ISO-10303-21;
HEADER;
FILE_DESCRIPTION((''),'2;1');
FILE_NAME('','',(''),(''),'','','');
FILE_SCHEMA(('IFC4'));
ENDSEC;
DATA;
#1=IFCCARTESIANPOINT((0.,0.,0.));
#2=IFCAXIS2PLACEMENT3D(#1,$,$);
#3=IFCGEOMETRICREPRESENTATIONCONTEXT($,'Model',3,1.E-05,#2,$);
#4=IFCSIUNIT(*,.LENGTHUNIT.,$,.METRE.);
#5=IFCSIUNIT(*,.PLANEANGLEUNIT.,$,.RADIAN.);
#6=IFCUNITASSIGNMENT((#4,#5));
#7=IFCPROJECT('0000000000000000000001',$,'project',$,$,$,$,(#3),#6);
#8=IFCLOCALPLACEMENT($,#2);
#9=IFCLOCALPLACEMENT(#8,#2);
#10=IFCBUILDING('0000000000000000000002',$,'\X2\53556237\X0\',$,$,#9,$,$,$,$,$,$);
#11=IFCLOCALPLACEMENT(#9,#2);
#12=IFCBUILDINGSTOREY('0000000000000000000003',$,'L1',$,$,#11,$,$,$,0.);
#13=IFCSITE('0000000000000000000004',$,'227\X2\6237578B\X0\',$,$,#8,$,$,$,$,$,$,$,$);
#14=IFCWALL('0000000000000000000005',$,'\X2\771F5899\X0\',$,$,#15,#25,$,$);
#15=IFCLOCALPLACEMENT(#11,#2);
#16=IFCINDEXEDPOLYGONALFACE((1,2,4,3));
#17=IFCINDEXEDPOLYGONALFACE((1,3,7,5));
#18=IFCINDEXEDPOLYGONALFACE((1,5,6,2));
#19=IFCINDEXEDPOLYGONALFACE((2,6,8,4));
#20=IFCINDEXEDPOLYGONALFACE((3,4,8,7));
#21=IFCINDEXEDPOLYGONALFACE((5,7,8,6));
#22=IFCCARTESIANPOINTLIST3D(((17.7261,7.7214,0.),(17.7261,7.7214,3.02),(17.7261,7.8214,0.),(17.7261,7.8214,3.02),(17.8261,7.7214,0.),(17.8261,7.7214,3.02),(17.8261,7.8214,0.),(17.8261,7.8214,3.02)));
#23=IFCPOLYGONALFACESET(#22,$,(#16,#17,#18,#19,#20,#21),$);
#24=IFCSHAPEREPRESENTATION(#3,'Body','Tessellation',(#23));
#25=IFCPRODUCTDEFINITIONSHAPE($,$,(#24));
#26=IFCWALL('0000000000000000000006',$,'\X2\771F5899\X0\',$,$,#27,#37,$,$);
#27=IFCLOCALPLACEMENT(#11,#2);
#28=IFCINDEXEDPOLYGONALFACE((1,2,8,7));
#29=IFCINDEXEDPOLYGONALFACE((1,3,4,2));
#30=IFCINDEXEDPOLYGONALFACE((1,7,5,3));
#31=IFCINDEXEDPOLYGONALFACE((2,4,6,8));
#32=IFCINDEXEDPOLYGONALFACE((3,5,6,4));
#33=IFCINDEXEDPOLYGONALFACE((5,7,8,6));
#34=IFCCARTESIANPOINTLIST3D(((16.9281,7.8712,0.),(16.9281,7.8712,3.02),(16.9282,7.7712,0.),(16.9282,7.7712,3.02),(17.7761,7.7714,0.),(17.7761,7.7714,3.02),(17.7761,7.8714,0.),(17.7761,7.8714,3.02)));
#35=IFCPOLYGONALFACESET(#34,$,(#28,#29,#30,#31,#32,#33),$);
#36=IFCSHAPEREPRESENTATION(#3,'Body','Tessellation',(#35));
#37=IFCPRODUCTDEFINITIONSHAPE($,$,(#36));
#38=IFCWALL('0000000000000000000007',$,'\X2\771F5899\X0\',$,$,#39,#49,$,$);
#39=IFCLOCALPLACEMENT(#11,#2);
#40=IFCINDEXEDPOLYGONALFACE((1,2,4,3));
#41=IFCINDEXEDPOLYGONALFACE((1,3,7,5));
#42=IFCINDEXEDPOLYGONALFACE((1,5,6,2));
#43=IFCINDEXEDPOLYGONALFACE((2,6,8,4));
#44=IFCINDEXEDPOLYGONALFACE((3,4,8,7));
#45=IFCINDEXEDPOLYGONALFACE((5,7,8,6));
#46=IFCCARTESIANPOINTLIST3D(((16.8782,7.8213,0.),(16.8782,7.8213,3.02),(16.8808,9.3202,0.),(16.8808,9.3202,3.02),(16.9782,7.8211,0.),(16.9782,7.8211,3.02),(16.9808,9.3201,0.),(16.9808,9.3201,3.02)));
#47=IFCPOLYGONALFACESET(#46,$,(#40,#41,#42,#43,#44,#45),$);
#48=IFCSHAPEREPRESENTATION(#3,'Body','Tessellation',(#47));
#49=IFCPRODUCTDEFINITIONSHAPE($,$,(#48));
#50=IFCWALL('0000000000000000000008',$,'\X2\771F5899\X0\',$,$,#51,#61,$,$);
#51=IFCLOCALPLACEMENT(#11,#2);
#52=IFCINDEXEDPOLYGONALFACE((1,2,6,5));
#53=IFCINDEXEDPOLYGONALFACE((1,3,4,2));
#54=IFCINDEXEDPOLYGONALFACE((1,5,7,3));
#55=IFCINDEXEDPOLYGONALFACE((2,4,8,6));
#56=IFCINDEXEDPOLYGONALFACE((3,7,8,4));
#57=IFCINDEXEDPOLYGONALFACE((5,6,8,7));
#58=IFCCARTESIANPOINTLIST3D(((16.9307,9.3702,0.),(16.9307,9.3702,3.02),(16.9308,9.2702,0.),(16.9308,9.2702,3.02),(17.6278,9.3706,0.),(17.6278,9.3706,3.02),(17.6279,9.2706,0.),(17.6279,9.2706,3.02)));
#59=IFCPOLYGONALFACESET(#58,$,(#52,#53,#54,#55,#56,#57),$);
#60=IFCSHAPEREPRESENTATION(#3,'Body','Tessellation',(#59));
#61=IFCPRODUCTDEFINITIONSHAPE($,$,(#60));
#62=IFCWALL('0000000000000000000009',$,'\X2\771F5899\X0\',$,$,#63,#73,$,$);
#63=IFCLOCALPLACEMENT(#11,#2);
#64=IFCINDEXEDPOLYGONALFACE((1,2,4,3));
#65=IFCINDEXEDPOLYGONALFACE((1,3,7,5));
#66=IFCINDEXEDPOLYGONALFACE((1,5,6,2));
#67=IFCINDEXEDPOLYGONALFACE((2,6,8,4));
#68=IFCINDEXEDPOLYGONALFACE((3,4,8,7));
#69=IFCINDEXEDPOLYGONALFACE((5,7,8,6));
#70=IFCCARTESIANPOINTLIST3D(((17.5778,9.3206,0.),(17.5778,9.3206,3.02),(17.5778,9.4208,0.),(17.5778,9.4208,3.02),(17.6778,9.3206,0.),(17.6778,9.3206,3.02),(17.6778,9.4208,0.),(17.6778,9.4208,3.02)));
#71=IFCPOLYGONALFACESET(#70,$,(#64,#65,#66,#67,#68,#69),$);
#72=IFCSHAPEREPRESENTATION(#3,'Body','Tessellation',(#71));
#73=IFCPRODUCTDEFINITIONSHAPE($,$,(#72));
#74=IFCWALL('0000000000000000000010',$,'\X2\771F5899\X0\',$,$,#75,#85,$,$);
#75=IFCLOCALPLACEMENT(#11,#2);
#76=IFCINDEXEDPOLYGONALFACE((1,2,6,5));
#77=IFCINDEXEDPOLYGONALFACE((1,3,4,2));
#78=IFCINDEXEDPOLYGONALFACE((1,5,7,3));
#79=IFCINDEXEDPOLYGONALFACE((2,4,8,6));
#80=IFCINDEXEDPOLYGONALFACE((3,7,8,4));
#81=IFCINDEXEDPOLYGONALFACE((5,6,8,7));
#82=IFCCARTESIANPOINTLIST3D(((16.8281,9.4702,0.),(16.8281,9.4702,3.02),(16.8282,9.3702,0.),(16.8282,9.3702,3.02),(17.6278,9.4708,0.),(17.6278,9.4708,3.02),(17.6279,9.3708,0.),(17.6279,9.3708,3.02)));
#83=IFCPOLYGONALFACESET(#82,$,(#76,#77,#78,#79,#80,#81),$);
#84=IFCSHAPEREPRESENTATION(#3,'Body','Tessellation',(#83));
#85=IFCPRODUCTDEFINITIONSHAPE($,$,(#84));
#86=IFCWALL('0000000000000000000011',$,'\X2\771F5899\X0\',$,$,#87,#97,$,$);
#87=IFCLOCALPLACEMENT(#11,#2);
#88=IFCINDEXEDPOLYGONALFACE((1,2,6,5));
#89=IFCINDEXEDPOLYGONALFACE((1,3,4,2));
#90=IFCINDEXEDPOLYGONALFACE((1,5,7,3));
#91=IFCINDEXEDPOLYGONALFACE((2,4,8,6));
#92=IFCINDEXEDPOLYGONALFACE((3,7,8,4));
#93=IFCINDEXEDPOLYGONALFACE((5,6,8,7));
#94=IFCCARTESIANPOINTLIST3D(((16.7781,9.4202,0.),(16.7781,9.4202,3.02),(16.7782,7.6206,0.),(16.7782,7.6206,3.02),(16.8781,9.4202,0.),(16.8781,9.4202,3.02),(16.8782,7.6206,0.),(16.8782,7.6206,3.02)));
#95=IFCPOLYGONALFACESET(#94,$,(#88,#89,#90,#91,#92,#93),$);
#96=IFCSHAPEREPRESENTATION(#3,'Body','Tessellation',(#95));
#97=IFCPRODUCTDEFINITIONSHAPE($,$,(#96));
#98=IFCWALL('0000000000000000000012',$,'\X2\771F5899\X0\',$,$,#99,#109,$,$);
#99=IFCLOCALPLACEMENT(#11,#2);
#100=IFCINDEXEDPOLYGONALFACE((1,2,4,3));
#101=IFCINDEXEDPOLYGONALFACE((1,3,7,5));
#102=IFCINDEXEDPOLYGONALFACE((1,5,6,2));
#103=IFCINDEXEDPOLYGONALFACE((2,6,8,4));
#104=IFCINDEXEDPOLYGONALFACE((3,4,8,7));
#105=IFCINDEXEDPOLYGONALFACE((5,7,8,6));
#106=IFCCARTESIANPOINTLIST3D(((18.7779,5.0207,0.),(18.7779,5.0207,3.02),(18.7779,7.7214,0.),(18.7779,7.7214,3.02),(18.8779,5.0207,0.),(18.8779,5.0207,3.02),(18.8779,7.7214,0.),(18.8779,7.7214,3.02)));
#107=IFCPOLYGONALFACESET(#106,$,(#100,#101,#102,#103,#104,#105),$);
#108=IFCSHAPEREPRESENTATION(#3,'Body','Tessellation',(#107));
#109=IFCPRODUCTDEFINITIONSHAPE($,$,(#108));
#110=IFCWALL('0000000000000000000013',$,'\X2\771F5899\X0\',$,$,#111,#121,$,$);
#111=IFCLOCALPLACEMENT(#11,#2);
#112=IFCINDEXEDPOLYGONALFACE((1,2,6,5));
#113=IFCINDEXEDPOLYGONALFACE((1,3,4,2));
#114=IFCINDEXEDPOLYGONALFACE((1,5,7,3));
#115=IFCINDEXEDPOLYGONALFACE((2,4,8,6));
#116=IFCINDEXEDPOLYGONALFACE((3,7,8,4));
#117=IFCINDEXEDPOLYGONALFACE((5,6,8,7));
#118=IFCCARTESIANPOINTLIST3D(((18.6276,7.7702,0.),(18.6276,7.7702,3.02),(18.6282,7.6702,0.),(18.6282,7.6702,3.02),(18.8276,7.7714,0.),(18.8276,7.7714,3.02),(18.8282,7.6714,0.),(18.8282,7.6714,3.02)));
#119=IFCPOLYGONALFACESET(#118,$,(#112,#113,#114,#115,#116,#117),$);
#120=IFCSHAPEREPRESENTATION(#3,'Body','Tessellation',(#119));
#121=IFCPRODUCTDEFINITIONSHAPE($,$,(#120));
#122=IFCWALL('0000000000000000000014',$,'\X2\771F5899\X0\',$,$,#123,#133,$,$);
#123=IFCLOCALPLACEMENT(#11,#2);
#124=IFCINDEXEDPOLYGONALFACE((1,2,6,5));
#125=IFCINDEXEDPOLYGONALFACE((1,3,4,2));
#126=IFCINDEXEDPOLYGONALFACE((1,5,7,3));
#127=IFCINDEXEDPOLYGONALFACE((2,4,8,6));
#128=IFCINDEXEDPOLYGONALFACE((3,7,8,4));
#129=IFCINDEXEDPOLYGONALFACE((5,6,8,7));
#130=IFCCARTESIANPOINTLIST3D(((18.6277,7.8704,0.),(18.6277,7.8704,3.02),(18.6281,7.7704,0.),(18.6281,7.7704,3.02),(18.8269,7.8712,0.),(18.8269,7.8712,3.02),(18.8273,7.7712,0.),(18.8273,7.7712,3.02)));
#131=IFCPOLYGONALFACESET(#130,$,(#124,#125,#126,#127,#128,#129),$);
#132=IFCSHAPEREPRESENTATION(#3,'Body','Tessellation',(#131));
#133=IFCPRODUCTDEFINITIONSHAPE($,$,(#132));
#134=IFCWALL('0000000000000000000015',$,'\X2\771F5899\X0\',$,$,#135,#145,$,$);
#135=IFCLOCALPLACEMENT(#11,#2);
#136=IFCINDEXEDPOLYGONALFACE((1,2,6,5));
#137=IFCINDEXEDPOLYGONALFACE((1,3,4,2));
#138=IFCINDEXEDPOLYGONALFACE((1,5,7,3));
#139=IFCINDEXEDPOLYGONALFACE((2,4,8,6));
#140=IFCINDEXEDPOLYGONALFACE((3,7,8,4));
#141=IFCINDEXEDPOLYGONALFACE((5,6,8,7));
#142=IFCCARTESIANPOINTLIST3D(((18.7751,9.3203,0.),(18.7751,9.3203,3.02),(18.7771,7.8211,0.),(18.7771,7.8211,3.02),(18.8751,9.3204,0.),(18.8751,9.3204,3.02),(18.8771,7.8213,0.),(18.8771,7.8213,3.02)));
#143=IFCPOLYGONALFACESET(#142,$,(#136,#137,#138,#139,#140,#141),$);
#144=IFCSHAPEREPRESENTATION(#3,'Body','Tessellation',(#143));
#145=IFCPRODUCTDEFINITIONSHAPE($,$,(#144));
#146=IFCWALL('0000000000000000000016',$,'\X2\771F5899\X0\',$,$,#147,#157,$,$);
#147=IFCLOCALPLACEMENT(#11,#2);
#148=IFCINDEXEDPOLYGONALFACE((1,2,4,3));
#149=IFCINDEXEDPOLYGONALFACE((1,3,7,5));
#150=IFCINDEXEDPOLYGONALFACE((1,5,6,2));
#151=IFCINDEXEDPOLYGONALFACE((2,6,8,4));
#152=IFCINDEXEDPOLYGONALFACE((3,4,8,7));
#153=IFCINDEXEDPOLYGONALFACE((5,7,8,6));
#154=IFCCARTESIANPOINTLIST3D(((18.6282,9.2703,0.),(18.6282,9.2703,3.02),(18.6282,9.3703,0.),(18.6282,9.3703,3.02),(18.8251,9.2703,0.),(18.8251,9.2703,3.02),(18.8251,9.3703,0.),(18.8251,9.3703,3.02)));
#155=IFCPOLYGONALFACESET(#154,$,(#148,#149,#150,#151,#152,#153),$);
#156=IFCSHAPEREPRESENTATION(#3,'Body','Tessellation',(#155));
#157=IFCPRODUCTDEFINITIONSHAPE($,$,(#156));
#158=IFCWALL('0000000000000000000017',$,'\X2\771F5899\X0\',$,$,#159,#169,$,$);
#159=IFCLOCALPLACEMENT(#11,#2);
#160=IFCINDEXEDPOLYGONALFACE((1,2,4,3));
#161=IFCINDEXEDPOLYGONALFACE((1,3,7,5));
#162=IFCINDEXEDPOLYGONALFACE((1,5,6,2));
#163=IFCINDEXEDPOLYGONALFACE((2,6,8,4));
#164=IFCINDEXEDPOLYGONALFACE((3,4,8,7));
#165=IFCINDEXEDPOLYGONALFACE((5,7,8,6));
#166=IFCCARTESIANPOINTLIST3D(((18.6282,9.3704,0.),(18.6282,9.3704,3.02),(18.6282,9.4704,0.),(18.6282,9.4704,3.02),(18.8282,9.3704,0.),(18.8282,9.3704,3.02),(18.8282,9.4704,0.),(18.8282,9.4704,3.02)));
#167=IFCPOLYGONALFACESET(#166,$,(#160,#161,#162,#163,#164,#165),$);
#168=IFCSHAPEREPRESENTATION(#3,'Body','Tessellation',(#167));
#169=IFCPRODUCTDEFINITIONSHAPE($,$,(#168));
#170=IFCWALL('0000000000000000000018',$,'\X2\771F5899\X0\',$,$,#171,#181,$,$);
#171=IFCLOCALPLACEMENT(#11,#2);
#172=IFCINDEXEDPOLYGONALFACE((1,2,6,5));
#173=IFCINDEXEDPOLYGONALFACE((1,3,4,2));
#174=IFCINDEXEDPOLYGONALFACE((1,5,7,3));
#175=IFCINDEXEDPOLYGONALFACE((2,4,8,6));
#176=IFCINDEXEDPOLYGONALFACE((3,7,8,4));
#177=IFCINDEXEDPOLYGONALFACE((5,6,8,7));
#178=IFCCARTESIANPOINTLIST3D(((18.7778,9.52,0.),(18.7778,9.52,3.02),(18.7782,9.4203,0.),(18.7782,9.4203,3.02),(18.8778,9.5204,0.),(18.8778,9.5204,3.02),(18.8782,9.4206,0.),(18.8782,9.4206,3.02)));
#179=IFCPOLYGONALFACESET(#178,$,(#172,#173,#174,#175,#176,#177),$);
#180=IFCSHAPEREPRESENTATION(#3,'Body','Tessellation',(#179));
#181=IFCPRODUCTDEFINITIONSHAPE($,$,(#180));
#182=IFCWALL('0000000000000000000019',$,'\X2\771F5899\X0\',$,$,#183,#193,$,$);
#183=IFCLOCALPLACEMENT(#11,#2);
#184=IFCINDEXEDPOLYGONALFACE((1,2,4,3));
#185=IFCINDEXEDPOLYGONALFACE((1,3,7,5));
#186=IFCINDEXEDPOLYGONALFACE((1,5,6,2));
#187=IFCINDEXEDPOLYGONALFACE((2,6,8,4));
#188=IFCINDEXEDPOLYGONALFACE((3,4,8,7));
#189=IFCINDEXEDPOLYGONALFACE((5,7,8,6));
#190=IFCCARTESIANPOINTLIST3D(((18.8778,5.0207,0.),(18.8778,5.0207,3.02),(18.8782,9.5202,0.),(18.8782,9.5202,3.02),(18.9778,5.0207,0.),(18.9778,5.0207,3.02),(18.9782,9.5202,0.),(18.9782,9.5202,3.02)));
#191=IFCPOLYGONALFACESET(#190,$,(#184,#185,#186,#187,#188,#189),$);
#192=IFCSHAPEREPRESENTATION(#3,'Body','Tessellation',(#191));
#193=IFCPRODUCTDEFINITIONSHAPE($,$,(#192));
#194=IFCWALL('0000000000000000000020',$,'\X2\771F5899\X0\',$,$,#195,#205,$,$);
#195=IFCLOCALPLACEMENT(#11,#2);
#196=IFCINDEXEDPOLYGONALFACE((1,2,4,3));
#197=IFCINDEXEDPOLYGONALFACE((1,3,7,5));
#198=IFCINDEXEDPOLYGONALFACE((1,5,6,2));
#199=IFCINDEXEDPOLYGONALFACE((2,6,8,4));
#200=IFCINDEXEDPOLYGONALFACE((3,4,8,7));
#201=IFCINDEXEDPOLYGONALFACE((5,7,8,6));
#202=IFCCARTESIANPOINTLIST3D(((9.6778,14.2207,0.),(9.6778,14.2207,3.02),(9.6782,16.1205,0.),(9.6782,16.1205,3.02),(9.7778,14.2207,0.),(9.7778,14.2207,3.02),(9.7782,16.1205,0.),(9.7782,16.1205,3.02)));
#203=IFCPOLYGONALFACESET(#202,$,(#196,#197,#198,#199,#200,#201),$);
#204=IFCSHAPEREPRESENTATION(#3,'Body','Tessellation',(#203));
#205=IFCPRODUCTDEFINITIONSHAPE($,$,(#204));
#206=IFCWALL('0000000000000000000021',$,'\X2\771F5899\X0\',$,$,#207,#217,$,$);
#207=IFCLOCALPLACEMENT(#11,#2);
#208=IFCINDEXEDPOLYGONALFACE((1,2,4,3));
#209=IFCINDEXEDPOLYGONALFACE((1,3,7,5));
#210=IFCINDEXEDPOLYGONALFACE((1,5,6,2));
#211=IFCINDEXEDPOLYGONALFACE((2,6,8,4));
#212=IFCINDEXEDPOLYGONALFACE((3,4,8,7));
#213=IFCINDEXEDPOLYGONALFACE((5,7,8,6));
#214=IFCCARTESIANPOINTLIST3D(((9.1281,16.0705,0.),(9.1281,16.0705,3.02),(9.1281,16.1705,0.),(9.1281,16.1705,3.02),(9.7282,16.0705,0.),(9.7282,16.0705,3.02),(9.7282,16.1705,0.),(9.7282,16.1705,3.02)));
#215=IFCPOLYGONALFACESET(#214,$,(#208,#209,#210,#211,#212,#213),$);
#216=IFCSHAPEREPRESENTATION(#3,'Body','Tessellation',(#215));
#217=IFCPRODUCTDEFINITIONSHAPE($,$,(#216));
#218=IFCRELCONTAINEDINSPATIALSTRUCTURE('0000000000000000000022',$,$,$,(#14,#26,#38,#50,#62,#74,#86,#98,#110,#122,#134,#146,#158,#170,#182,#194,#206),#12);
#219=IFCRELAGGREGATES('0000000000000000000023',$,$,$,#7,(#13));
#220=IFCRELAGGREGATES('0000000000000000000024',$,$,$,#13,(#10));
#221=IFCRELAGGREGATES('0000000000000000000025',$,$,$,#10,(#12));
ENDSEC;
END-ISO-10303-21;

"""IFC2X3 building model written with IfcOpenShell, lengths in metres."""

from ifc_helpers import new_model, si_unit, origin, place, context, project, spatial, polyline, outline, extrude, element, save


model = new_model("IFC2X3")

# Units and contexts
model_context = context("Model", 3, precision=1e-05, world=origin())
ifc_project = project(units=[si_unit("LENGTHUNIT", "METRE"), si_unit("PLANEANGLEUNIT", "RADIAN")], contexts=[model_context])

# Site, building, storey
site_placement = place(None, origin())
site = spatial("IfcSite", under=ifc_project, at=site_placement, Name="227户型")
building_placement = place(site_placement, origin())
building = spatial("IfcBuilding", under=site, at=building_placement, Name="单户")
storey_placement = place(building_placement, origin())
storey = spatial("IfcBuildingStorey", under=building, at=storey_placement, Name="L1", Elevation=0.0)

# Walls
wall_1_placement = place(storey_placement, origin())
element("IfcWall", 1, at=wall_1_placement, inside=storey, Name="真墙", context=model_context, shape_type="SweptSolid", body=[
    extrude(outline(polyline([(17.7261, 7.7214), (17.7261, 7.8214), (17.8261, 7.8214), (17.8261, 7.7214), (17.7261, 7.7214)])), origin(), (0.0, 0.0, 1.0), 3.02),
])
wall_2_placement = place(storey_placement, origin())
element("IfcWall", 2, at=wall_2_placement, inside=storey, Name="真墙", context=model_context, shape_type="SweptSolid", body=[
    extrude(outline(polyline([(17.7761, 7.7714), (16.9282, 7.7712), (16.9281, 7.8712), (17.7761, 7.8714), (17.7761, 7.7714)])), origin(), (0.0, 0.0, 1.0), 3.02),
])
wall_3_placement = place(storey_placement, origin())
element("IfcWall", 3, at=wall_3_placement, inside=storey, Name="真墙", context=model_context, shape_type="SweptSolid", body=[
    extrude(outline(polyline([(16.8782, 7.8213), (16.8808, 9.3202), (16.9808, 9.3201), (16.9782, 7.8211), (16.8782, 7.8213)])), origin(), (0.0, 0.0, 1.0), 3.02),
])
wall_4_placement = place(storey_placement, origin())
element("IfcWall", 4, at=wall_4_placement, inside=storey, Name="真墙", context=model_context, shape_type="SweptSolid", body=[
    extrude(outline(polyline([(16.9307, 9.3702), (17.6278, 9.3706), (17.6279, 9.2706), (16.9308, 9.2702), (16.9307, 9.3702)])), origin(), (0.0, 0.0, 1.0), 3.02),
])
wall_5_placement = place(storey_placement, origin())
element("IfcWall", 5, at=wall_5_placement, inside=storey, Name="真墙", context=model_context, shape_type="SweptSolid", body=[
    extrude(outline(polyline([(17.5778, 9.3206), (17.5778, 9.4208), (17.6778, 9.4208), (17.6778, 9.3206), (17.5778, 9.3206)])), origin(), (0.0, 0.0, 1.0), 3.02),
])
wall_6_placement = place(storey_placement, origin())
element("IfcWall", 6, at=wall_6_placement, inside=storey, Name="真墙", context=model_context, shape_type="SweptSolid", body=[
    extrude(outline(polyline([(17.6279, 9.3708), (16.8282, 9.3702), (16.8281, 9.4702), (17.6278, 9.4708), (17.6279, 9.3708)])), origin(), (0.0, 0.0, 1.0), 3.02),
])
wall_7_placement = place(storey_placement, origin())
element("IfcWall", 7, at=wall_7_placement, inside=storey, Name="真墙", context=model_context, shape_type="SweptSolid", body=[
    extrude(outline(polyline([(16.8781, 9.4202), (16.8782, 7.6206), (16.7782, 7.6206), (16.7781, 9.4202), (16.8781, 9.4202)])), origin(), (0.0, 0.0, 1.0), 3.02),
])
wall_8_placement = place(storey_placement, origin())
element("IfcWall", 8, at=wall_8_placement, inside=storey, Name="真墙", context=model_context, shape_type="SweptSolid", body=[
    extrude(outline(polyline([(18.7779, 5.0207), (18.7779, 7.7214), (18.8779, 7.7214), (18.8779, 5.0207), (18.7779, 5.0207)])), origin(), (0.0, 0.0, 1.0), 3.02),
])
wall_9_placement = place(storey_placement, origin())
element("IfcWall", 9, at=wall_9_placement, inside=storey, Name="真墙", context=model_context, shape_type="SweptSolid", body=[
    extrude(outline(polyline([(18.8282, 7.6714), (18.6282, 7.6702), (18.6276, 7.7702), (18.8276, 7.7714), (18.8282, 7.6714)])), origin(), (0.0, 0.0, 1.0), 3.02),
])

# Walls
wall_10_placement = place(storey_placement, origin())
element("IfcWall", 10, at=wall_10_placement, inside=storey, Name="真墙", context=model_context, shape_type="SweptSolid", body=[
    extrude(outline(polyline([(18.6277, 7.8704), (18.8269, 7.8712), (18.8273, 7.7712), (18.6281, 7.7704), (18.6277, 7.8704)])), origin(), (0.0, 0.0, 1.0), 3.02),
])
wall_11_placement = place(storey_placement, origin())
element("IfcWall", 11, at=wall_11_placement, inside=storey, Name="真墙", context=model_context, shape_type="SweptSolid", body=[
    extrude(outline(polyline([(18.7771, 7.8211), (18.7751, 9.3203), (18.8751, 9.3204), (18.8771, 7.8213), (18.7771, 7.8211)])), origin(), (0.0, 0.0, 1.0), 3.02),
])
wall_12_placement = place(storey_placement, origin())
element("IfcWall", 12, at=wall_12_placement, inside=storey, Name="真墙", context=model_context, shape_type="SweptSolid", body=[
    extrude(outline(polyline([(18.8251, 9.2703), (18.6282, 9.2703), (18.6282, 9.3703), (18.8251, 9.3703), (18.8251, 9.2703)])), origin(), (0.0, 0.0, 1.0), 3.02),
])

# Walls
wall_13_placement = place(storey_placement, origin())
element("IfcWall", 13, at=wall_13_placement, inside=storey, Name="真墙", context=model_context, shape_type="SweptSolid", body=[
    extrude(outline(polyline([(18.6282, 9.4704), (18.8282, 9.4704), (18.8282, 9.3704), (18.6282, 9.3704), (18.6282, 9.4704)])), origin(), (0.0, 0.0, 1.0), 3.02),
])
wall_14_placement = place(storey_placement, origin())
element("IfcWall", 14, at=wall_14_placement, inside=storey, Name="真墙", context=model_context, shape_type="SweptSolid", body=[
    extrude(outline(polyline([(18.7782, 9.4203), (18.7778, 9.52), (18.8778, 9.5204), (18.8782, 9.4206), (18.7782, 9.4203)])), origin(), (0.0, 0.0, 1.0), 3.02),
])

# Walls
wall_15_placement = place(storey_placement, origin())
element("IfcWall", 15, at=wall_15_placement, inside=storey, Name="真墙", context=model_context, shape_type="SweptSolid", body=[
    extrude(outline(polyline([(18.9782, 9.5202), (18.9778, 5.0207), (18.8778, 5.0207), (18.8782, 9.5202), (18.9782, 9.5202)])), origin(), (0.0, 0.0, 1.0), 3.02),
])
wall_16_placement = place(storey_placement, origin())
element("IfcWall", 16, at=wall_16_placement, inside=storey, Name="真墙", context=model_context, shape_type="SweptSolid", body=[
    extrude(outline(polyline([(9.6778, 14.2207), (9.6782, 16.1205), (9.7782, 16.1205), (9.7778, 14.2207), (9.6778, 14.2207)])), origin(), (0.0, 0.0, 1.0), 3.02),
])
wall_17_placement = place(storey_placement, origin())
element("IfcWall", 17, at=wall_17_placement, inside=storey, Name="真墙", context=model_context, shape_type="SweptSolid", body=[
    extrude(outline(polyline([(9.7282, 16.0705), (9.1281, 16.0705), (9.1281, 16.1705), (9.7282, 16.1705), (9.7282, 16.0705)])), origin(), (0.0, 0.0, 1.0), 3.02),
])

save(model, "model.ifc")
